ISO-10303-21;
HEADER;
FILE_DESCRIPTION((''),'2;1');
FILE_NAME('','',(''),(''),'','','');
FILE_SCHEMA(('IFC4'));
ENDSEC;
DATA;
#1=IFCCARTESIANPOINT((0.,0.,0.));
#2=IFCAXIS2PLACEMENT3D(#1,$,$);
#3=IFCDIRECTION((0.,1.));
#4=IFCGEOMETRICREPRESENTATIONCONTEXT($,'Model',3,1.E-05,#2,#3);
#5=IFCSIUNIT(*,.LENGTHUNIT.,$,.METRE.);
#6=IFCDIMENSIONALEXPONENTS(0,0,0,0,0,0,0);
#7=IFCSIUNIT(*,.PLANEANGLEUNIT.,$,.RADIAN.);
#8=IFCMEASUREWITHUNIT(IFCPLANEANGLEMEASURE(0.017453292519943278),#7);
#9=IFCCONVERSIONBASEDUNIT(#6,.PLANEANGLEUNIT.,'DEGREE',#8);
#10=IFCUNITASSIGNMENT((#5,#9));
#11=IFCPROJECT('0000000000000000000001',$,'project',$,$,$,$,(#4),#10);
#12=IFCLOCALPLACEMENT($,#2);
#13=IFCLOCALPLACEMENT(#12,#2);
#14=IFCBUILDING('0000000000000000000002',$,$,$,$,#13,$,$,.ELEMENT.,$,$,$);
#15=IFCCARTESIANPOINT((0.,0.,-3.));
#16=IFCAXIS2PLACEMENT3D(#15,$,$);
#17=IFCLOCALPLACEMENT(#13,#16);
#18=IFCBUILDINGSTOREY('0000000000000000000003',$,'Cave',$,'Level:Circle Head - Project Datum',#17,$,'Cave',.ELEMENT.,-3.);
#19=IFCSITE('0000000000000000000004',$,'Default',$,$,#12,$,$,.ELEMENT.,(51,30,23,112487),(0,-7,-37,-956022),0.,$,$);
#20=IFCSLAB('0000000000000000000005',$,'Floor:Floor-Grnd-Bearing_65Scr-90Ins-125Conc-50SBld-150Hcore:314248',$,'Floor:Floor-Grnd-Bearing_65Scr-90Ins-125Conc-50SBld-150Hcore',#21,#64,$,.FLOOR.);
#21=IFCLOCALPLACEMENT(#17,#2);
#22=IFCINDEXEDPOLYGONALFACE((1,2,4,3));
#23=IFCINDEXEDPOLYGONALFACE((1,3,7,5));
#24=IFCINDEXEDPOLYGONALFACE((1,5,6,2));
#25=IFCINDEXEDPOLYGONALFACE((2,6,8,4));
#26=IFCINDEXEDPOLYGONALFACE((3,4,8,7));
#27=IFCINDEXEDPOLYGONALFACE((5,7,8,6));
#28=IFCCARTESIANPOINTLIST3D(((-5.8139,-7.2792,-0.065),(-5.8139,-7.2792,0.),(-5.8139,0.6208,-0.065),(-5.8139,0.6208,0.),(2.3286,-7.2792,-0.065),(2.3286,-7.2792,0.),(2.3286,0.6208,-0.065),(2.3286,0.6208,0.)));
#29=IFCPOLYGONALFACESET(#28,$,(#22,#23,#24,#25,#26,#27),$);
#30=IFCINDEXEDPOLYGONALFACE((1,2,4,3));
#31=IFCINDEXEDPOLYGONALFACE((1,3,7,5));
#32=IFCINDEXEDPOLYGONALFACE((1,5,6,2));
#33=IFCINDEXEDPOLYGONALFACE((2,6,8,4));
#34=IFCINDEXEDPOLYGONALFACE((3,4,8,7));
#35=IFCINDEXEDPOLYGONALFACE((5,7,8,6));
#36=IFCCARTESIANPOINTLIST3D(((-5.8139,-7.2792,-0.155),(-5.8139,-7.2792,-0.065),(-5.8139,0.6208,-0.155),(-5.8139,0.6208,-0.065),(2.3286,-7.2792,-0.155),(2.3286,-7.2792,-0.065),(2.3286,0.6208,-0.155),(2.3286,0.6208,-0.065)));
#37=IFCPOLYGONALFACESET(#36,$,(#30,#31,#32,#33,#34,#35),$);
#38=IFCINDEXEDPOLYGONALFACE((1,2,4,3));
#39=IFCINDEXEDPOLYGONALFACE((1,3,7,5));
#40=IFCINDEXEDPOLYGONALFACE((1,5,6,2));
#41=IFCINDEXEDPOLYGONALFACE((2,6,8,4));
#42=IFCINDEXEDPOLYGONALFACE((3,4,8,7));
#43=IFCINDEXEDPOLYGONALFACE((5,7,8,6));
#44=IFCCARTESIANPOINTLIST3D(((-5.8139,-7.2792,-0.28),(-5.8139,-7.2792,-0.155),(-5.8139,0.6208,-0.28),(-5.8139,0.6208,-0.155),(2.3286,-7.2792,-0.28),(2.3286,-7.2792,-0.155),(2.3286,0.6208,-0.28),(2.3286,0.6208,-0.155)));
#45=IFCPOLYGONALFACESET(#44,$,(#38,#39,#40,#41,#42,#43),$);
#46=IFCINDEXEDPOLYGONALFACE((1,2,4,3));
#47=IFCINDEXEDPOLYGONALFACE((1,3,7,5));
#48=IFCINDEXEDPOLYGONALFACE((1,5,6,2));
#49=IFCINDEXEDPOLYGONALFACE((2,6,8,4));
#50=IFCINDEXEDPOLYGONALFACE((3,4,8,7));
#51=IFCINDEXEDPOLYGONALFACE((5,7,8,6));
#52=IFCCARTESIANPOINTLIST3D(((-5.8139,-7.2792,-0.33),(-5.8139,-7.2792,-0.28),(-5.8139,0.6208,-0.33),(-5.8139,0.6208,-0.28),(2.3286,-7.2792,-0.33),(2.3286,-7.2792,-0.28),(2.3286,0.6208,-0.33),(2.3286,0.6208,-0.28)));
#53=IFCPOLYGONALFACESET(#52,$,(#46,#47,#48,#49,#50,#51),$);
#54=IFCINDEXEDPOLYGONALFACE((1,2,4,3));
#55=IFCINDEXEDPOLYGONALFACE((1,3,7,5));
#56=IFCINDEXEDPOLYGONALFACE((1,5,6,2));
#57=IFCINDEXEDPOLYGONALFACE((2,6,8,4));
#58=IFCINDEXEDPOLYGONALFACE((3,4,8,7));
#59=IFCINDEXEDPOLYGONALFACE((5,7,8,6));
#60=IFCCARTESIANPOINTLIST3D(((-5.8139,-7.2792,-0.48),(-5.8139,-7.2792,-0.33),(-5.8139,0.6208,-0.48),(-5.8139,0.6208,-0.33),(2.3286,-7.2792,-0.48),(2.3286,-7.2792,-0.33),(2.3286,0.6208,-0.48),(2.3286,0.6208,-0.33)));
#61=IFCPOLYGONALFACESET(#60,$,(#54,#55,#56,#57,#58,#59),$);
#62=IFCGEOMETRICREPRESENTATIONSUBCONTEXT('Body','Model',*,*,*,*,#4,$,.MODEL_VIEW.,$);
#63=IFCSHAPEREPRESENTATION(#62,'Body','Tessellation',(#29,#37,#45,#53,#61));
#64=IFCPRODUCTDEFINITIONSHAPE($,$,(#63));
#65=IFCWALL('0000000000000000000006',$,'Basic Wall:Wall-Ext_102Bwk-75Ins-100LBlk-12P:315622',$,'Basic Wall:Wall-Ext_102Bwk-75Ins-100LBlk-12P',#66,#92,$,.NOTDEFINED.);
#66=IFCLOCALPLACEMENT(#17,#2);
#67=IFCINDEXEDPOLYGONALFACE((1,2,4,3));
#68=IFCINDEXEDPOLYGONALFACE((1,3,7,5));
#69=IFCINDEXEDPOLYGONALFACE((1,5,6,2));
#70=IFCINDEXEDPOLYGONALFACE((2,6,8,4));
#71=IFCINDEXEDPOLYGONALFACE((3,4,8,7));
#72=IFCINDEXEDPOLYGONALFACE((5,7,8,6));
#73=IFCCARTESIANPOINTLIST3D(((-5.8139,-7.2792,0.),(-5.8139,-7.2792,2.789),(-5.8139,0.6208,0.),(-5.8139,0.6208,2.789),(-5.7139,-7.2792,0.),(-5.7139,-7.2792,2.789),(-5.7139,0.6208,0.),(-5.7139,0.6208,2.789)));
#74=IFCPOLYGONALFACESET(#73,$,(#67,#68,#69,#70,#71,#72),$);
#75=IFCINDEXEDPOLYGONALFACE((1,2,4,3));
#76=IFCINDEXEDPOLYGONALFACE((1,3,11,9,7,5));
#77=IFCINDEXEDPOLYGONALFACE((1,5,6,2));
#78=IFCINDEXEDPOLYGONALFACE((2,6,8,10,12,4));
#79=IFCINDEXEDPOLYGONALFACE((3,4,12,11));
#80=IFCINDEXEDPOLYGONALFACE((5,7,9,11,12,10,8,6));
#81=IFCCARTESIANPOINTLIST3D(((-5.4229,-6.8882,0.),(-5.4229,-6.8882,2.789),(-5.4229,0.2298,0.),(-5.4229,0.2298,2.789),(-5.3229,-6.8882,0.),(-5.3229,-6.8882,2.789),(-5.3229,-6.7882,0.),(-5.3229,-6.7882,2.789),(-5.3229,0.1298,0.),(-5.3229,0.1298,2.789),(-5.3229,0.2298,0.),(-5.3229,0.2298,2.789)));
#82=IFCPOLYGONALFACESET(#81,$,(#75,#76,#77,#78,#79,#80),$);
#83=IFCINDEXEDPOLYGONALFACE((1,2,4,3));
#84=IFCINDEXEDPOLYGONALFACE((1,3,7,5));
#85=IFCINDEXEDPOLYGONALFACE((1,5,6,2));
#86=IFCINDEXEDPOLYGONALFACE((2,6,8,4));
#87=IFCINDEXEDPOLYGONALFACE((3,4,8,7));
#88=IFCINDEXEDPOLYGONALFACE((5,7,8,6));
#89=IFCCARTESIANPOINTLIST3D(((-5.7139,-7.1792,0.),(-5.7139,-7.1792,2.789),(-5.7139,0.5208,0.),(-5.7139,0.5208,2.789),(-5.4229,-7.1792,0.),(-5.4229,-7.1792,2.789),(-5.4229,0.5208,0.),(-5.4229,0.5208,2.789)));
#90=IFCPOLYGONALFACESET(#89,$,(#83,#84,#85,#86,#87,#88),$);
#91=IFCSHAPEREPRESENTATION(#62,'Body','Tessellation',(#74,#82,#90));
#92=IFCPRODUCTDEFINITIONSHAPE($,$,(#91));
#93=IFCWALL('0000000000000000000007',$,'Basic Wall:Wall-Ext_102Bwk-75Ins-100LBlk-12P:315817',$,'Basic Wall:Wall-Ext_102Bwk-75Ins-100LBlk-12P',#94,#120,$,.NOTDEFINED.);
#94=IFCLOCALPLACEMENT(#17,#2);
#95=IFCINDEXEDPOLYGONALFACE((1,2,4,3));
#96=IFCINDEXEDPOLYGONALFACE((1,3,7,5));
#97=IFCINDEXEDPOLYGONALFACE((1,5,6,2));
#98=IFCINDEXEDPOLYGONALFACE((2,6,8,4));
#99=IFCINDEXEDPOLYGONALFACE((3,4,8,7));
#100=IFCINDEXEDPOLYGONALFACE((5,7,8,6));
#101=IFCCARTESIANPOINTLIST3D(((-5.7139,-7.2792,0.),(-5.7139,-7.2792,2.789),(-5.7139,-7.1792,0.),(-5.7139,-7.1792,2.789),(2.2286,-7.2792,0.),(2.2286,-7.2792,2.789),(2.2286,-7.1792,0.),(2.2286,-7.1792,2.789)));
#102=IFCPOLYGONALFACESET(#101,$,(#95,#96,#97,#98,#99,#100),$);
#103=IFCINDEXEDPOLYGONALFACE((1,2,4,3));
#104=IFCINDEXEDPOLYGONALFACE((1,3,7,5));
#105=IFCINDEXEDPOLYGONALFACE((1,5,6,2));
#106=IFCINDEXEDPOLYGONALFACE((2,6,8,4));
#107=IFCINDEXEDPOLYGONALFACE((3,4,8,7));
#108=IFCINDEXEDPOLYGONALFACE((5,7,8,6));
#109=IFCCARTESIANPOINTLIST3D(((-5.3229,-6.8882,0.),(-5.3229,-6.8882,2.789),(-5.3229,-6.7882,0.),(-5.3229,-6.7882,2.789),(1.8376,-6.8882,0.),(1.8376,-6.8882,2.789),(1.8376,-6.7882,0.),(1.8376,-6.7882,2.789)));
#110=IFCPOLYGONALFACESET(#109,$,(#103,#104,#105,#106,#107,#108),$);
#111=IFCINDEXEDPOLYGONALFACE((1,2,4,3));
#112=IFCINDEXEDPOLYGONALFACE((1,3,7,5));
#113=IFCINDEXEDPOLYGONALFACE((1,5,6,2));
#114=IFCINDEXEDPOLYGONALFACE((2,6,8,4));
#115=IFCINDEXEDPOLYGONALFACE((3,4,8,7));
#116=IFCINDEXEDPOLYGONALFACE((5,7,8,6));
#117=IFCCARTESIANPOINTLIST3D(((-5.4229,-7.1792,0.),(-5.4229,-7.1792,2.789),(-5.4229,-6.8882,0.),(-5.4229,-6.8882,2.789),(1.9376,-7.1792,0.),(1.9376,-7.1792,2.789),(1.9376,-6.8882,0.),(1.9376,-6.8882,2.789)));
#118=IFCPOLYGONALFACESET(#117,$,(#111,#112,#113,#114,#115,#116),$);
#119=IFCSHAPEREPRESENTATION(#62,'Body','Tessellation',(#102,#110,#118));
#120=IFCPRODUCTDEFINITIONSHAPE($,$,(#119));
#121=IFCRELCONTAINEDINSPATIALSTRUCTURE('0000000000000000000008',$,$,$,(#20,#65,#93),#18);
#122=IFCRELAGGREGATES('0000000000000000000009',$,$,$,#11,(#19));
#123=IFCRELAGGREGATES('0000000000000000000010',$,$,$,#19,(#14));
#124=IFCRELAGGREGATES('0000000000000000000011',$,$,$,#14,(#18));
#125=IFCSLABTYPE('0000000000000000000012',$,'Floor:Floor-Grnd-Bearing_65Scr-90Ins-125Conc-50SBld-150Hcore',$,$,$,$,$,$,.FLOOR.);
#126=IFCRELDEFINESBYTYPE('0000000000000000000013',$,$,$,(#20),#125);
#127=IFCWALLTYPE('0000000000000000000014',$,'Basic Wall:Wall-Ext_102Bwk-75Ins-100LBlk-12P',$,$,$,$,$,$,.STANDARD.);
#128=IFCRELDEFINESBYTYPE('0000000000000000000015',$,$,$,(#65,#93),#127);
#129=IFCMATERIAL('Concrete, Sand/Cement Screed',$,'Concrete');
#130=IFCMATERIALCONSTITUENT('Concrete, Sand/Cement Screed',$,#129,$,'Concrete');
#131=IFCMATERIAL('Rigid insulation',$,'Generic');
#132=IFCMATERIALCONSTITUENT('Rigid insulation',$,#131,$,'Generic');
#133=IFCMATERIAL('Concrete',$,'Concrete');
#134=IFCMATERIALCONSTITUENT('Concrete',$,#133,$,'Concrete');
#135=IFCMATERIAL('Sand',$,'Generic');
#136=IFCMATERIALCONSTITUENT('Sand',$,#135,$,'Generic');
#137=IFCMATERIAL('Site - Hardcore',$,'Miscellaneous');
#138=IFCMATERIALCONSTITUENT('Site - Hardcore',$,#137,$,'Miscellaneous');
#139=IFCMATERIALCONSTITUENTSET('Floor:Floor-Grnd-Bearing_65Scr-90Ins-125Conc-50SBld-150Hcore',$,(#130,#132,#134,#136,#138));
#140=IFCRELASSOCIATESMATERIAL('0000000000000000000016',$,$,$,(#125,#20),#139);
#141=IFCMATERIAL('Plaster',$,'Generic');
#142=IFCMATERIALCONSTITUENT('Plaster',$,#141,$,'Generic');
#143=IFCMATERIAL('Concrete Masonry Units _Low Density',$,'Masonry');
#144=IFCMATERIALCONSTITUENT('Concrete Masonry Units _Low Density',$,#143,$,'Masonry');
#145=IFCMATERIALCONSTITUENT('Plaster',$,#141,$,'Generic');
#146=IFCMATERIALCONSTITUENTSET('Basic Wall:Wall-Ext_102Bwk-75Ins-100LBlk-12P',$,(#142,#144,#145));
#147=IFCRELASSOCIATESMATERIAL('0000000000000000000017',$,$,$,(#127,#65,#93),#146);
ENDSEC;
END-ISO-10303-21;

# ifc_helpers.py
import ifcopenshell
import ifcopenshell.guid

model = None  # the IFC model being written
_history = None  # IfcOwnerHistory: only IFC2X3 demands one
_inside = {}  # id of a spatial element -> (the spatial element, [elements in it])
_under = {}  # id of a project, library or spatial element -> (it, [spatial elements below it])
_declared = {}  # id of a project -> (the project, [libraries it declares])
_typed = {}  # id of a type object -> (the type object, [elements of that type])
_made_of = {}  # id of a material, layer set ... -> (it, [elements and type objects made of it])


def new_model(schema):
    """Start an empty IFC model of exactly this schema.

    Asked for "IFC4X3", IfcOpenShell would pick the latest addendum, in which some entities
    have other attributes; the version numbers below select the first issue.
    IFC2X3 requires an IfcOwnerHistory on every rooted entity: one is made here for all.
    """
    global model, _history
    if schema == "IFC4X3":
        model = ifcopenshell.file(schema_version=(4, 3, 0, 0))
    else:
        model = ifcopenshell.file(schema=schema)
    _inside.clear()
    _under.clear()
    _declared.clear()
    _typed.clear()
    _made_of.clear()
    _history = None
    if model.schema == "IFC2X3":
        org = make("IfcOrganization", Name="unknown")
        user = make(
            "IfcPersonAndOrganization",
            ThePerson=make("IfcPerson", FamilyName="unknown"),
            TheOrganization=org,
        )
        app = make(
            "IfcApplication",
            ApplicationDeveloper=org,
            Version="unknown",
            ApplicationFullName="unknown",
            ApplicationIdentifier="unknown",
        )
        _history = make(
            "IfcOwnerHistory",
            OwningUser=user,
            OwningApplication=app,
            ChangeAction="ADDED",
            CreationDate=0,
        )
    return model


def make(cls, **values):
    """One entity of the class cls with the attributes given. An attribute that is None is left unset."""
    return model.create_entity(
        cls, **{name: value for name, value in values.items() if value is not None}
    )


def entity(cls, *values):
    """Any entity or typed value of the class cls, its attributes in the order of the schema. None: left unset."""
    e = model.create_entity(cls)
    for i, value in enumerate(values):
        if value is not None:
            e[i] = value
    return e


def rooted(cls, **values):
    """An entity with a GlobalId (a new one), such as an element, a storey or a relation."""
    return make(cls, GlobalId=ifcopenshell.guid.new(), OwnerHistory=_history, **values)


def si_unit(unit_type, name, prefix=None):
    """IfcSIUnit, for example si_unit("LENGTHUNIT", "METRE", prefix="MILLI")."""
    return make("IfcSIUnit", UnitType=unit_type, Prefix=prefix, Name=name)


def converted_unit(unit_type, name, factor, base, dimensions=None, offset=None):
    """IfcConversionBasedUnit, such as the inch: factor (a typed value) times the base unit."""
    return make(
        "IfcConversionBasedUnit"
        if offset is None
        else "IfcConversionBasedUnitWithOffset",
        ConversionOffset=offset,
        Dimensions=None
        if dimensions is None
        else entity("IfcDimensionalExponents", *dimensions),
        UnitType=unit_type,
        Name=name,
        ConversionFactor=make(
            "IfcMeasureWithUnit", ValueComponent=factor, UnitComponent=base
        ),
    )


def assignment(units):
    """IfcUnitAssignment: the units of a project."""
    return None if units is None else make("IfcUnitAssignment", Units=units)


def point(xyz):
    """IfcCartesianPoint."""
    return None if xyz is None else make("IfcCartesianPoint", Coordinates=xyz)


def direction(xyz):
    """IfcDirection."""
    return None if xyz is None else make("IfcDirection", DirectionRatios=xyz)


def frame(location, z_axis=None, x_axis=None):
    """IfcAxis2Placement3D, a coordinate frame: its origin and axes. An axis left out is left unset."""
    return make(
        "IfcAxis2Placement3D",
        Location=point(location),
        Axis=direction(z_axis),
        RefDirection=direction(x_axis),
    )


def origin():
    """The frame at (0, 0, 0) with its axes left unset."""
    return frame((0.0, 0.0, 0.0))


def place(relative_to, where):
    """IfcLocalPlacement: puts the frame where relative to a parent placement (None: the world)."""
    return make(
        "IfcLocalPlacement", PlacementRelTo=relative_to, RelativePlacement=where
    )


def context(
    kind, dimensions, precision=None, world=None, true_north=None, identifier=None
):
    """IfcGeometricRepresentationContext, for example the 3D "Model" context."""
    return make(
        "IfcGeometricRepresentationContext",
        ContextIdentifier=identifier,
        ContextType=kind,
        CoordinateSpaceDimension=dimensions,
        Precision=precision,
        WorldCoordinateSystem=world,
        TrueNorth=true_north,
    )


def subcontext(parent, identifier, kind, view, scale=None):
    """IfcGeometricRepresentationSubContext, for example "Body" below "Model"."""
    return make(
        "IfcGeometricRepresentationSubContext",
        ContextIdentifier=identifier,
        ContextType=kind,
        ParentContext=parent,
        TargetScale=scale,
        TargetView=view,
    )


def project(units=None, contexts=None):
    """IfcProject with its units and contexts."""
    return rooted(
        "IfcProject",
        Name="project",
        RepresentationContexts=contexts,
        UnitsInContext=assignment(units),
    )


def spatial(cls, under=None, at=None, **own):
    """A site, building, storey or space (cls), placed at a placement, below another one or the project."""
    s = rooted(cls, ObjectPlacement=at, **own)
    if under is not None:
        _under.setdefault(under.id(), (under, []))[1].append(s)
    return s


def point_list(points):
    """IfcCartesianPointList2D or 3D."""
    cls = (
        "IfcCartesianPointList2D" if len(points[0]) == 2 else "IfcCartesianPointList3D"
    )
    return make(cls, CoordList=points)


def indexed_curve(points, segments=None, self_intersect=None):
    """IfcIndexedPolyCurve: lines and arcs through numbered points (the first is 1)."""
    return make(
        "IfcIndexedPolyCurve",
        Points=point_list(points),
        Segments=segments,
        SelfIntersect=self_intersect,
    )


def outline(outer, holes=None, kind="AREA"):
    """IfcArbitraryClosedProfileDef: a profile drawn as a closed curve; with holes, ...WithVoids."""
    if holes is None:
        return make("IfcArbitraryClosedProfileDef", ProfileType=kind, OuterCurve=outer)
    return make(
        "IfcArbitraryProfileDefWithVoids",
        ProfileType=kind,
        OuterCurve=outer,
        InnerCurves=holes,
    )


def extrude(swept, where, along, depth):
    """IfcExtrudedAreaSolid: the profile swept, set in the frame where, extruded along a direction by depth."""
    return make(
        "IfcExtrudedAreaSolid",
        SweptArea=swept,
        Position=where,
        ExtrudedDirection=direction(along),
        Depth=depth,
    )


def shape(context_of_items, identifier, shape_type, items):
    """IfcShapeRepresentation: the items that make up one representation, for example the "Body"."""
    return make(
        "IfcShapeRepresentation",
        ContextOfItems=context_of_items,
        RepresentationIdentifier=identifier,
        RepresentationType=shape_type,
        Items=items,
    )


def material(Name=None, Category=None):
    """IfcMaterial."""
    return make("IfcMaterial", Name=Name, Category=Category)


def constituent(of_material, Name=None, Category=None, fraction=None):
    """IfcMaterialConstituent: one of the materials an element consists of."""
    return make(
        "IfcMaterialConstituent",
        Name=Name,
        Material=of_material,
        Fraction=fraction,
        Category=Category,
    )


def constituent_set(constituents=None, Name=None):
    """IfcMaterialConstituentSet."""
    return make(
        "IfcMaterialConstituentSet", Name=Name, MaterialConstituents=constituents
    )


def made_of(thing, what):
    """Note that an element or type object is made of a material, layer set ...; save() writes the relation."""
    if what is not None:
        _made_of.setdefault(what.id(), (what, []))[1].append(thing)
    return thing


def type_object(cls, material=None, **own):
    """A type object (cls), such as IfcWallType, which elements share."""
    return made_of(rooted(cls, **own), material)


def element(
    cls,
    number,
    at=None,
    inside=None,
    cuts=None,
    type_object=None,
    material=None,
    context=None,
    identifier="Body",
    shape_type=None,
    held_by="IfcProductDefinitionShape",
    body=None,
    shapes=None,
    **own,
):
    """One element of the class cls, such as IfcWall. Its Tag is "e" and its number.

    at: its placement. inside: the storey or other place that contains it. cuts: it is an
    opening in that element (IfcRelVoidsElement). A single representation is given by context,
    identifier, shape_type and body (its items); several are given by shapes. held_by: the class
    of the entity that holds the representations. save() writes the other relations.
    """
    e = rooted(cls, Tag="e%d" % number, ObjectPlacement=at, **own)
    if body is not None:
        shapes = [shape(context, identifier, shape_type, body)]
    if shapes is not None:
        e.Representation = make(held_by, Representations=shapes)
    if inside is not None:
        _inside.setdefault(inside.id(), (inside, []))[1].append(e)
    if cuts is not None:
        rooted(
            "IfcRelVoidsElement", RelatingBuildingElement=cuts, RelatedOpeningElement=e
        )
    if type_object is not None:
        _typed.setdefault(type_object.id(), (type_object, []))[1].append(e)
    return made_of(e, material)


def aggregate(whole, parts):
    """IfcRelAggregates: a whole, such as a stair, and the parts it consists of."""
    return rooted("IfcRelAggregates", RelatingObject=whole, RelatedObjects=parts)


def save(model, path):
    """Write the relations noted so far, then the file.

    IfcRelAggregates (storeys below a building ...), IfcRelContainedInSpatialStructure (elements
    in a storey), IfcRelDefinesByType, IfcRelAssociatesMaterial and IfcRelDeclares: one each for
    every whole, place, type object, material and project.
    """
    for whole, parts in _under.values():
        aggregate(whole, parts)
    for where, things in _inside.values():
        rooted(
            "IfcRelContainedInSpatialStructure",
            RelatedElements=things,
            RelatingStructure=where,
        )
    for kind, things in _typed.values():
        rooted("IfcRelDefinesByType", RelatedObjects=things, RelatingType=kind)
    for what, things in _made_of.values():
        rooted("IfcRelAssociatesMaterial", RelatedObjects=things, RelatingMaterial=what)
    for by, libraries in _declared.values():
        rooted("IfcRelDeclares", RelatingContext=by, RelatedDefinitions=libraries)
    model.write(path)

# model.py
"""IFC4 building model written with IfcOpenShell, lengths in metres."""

from ifc_helpers import new_model, entity, si_unit, converted_unit, direction, frame, origin, place, context, subcontext, project, spatial, indexed_curve, outline, extrude, material, constituent, constituent_set, type_object, element, save


model = new_model("IFC4")

# Units and contexts
model_context = context("Model", 3, precision=1e-05, world=origin(), true_north=direction((0.0, 1.0)))
body_context = subcontext(model_context, "Body", "Model", "MODEL_VIEW")
ifc_project = project(units=[si_unit("LENGTHUNIT", "METRE"), converted_unit("PLANEANGLEUNIT", "DEGREE", entity("IfcPlaneAngleMeasure", 0.017453292519943278), si_unit("PLANEANGLEUNIT", "RADIAN"), dimensions=[0, 0, 0, 0, 0, 0, 0])], contexts=[model_context])

# Site, building, storey
site_placement = place(None, origin())
site = spatial("IfcSite", under=ifc_project, at=site_placement, Name="Default", CompositionType="ELEMENT", RefLatitude=(51, 30, 23, 112487), RefLongitude=(0, -7, -37, -956022), RefElevation=0.0)
building_placement = place(site_placement, origin())
building = spatial("IfcBuilding", under=site, at=building_placement, CompositionType="ELEMENT")
storey_placement = place(building_placement, frame((0.0, 0.0, -3.0)))
storey = spatial("IfcBuildingStorey", under=building, at=storey_placement, Name="Cave", ObjectType="Level:Circle Head - Project Datum", LongName="Cave", CompositionType="ELEMENT", Elevation=-3.0)

# Slab
ifc_material_1 = material(Name="Concrete, Sand/Cement Screed", Category="Concrete")
ifc_constituent_1 = constituent(ifc_material_1, Name="Concrete, Sand/Cement Screed", Category="Concrete")
ifc_material_2 = material(Name="Rigid insulation", Category="Generic")
ifc_constituent_2 = constituent(ifc_material_2, Name="Rigid insulation", Category="Generic")
ifc_material_3 = material(Name="Concrete", Category="Concrete")
ifc_constituent_3 = constituent(ifc_material_3, Name="Concrete", Category="Concrete")
ifc_material_4 = material(Name="Sand", Category="Generic")
ifc_constituent_4 = constituent(ifc_material_4, Name="Sand", Category="Generic")
ifc_material_5 = material(Name="Site - Hardcore", Category="Miscellaneous")
ifc_constituent_5 = constituent(ifc_material_5, Name="Site - Hardcore", Category="Miscellaneous")
ifc_constituent_set_1 = constituent_set(constituents=[ifc_constituent_1, ifc_constituent_2, ifc_constituent_3, ifc_constituent_4, ifc_constituent_5], Name="Floor:Floor-Grnd-Bearing_65Scr-90Ins-125Conc-50SBld-150Hcore")
slab_type = type_object("IfcSlabType", Name="Floor:Floor-Grnd-Bearing_65Scr-90Ins-125Conc-50SBld-150Hcore", PredefinedType="FLOOR", material=ifc_constituent_set_1)
slab_placement = place(storey_placement, origin())
element("IfcSlab", 1, at=slab_placement, inside=storey, type_object=slab_type, material=ifc_constituent_set_1, Name="Floor:Floor-Grnd-Bearing_65Scr-90Ins-125Conc-50SBld-150Hcore:314248", ObjectType="Floor:Floor-Grnd-Bearing_65Scr-90Ins-125Conc-50SBld-150Hcore", PredefinedType="FLOOR", context=body_context, shape_type="SweptSolid", body=[
    extrude(outline(indexed_curve([(-4.0712, -3.95), (4.0712, -3.95), (4.0712, 3.95), (-4.0712, 3.95), (-4.0712, -3.95)], self_intersect=False)), frame((-1.7426, -3.3292, -0.065), z_axis=(0.0, 0.0, 1.0), x_axis=(-1.0, 0.0, 0.0)), (0.0, 0.0, 1.0), 0.065),
    extrude(outline(indexed_curve([(-4.0712, -3.95), (4.0712, -3.95), (4.0712, 3.95), (-4.0712, 3.95), (-4.0712, -3.95)], self_intersect=False)), frame((-1.7426, -3.3292, -0.155), z_axis=(0.0, 0.0, 1.0), x_axis=(-1.0, 0.0, 0.0)), (0.0, 0.0, 1.0), 0.09),
    extrude(outline(indexed_curve([(-4.0712, -3.95), (4.0712, -3.95), (4.0712, 3.95), (-4.0712, 3.95), (-4.0712, -3.95)], self_intersect=False)), frame((-1.7426, -3.3292, -0.28), z_axis=(0.0, 0.0, 1.0), x_axis=(-1.0, 0.0, 0.0)), (0.0, 0.0, 1.0), 0.125),
    extrude(outline(indexed_curve([(-4.0712, -3.95), (4.0712, -3.95), (4.0712, 3.95), (-4.0712, 3.95), (-4.0712, -3.95)], self_intersect=False)), frame((-1.7426, -3.3292, -0.33), z_axis=(0.0, 0.0, 1.0), x_axis=(-1.0, 0.0, 0.0)), (0.0, 0.0, 1.0), 0.05),
    extrude(outline(indexed_curve([(-4.0712, -3.95), (4.0712, -3.95), (4.0712, 3.95), (-4.0712, 3.95), (-4.0712, -3.95)], self_intersect=False)), frame((-1.7426, -3.3292, -0.48), z_axis=(0.0, 0.0, 1.0), x_axis=(-1.0, 0.0, 0.0)), (0.0, 0.0, 1.0), 0.15),
])

# Walls
ifc_material_6 = material(Name="Plaster", Category="Generic")
ifc_constituent_6 = constituent(ifc_material_6, Name="Plaster", Category="Generic")
ifc_material_7 = material(Name="Concrete Masonry Units _Low Density", Category="Masonry")
ifc_constituent_7 = constituent(ifc_material_7, Name="Concrete Masonry Units _Low Density", Category="Masonry")
ifc_constituent_8 = constituent(ifc_material_6, Name="Plaster", Category="Generic")
ifc_constituent_set_2 = constituent_set(constituents=[ifc_constituent_6, ifc_constituent_7, ifc_constituent_8], Name="Basic Wall:Wall-Ext_102Bwk-75Ins-100LBlk-12P")
wall_type_1 = type_object("IfcWallType", Name="Basic Wall:Wall-Ext_102Bwk-75Ins-100LBlk-12P", PredefinedType="STANDARD", material=ifc_constituent_set_2)
wall_1_placement = place(storey_placement, frame((-5.5684, -7.2792, 0.0), z_axis=(0.0, 0.0, 1.0), x_axis=(0.0, 1.0, 0.0)))
element("IfcWall", 2, at=wall_1_placement, inside=storey, type_object=wall_type_1, material=ifc_constituent_set_2, Name="Basic Wall:Wall-Ext_102Bwk-75Ins-100LBlk-12P:315622", ObjectType="Basic Wall:Wall-Ext_102Bwk-75Ins-100LBlk-12P", PredefinedType="NOTDEFINED", context=body_context, shape_type="SweptSolid", body=[
    extrude(outline(indexed_curve([(-0.05, -3.95), (0.05, -3.95), (0.05, 3.95), (-0.05, 3.95), (-0.05, -3.95)], self_intersect=False)), frame((3.95, 0.1955, 0.0), z_axis=(0.0, 0.0, 1.0), x_axis=(0.0, -1.0, 0.0)), (0.0, 0.0, 1.0), 2.789),
    extrude(outline(indexed_curve([(-3.459, -0.0333), (3.459, -0.0333), (3.559, -0.0333), (3.559, 0.0667), (-3.559, 0.0667), (-3.559, -0.0333), (-3.459, -0.0333)], self_intersect=False)), frame((3.95, -0.2122, 0.0)), (0.0, 0.0, 1.0), 2.789),
    extrude(outline(indexed_curve([(-3.85, -0.1455), (3.85, -0.1455), (3.85, 0.1455), (-3.85, 0.1455), (-3.85, -0.1455)], self_intersect=False)), frame((3.95, 0.0, 0.0)), (0.0, 0.0, 1.0), 2.789),
])
wall_2_placement = place(storey_placement, frame((1.8376, -7.0337, 0.0), z_axis=(0.0, 0.0, 1.0), x_axis=(-1.0, 0.0, 0.0)))
element("IfcWall", 3, at=wall_2_placement, inside=storey, type_object=wall_type_1, material=ifc_constituent_set_2, Name="Basic Wall:Wall-Ext_102Bwk-75Ins-100LBlk-12P:315817", ObjectType="Basic Wall:Wall-Ext_102Bwk-75Ins-100LBlk-12P", PredefinedType="NOTDEFINED", context=body_context, shape_type="SweptSolid", body=[
    extrude(outline(indexed_curve([(-0.05, -1.3945), (0.05, -1.3945), (0.05, 1.3945), (-0.05, 1.3945), (-0.05, -1.3945)], self_intersect=False)), frame((7.5515, 0.1955, 1.3945), z_axis=(-1.0, 0.0, 0.0), x_axis=(0.0, -1.0, 0.0)), (0.0, 0.0, 1.0), 7.9425),
    extrude(outline(indexed_curve([(-0.05, -1.3945), (0.05, -1.3945), (0.05, 1.3945), (-0.05, 1.3945), (-0.05, -1.3945)], self_intersect=False)), frame((7.1605, -0.1955, 1.3945), z_axis=(-1.0, 0.0, 0.0), x_axis=(0.0, 1.0, 0.0)), (0.0, 0.0, 1.0), 7.1605),
    extrude(outline(indexed_curve([(-1.3945, -0.1455), (1.3945, -0.1455), (1.3945, 0.1455), (-1.3945, 0.1455), (-1.3945, -0.1455)], self_intersect=False)), frame((7.2605, 0.0, 1.3945), z_axis=(-1.0, 0.0, 0.0), x_axis=(0.0, 0.0, 1.0)), (0.0, 0.0, 1.0), 7.3605),
])

save(model, "model.ifc")
